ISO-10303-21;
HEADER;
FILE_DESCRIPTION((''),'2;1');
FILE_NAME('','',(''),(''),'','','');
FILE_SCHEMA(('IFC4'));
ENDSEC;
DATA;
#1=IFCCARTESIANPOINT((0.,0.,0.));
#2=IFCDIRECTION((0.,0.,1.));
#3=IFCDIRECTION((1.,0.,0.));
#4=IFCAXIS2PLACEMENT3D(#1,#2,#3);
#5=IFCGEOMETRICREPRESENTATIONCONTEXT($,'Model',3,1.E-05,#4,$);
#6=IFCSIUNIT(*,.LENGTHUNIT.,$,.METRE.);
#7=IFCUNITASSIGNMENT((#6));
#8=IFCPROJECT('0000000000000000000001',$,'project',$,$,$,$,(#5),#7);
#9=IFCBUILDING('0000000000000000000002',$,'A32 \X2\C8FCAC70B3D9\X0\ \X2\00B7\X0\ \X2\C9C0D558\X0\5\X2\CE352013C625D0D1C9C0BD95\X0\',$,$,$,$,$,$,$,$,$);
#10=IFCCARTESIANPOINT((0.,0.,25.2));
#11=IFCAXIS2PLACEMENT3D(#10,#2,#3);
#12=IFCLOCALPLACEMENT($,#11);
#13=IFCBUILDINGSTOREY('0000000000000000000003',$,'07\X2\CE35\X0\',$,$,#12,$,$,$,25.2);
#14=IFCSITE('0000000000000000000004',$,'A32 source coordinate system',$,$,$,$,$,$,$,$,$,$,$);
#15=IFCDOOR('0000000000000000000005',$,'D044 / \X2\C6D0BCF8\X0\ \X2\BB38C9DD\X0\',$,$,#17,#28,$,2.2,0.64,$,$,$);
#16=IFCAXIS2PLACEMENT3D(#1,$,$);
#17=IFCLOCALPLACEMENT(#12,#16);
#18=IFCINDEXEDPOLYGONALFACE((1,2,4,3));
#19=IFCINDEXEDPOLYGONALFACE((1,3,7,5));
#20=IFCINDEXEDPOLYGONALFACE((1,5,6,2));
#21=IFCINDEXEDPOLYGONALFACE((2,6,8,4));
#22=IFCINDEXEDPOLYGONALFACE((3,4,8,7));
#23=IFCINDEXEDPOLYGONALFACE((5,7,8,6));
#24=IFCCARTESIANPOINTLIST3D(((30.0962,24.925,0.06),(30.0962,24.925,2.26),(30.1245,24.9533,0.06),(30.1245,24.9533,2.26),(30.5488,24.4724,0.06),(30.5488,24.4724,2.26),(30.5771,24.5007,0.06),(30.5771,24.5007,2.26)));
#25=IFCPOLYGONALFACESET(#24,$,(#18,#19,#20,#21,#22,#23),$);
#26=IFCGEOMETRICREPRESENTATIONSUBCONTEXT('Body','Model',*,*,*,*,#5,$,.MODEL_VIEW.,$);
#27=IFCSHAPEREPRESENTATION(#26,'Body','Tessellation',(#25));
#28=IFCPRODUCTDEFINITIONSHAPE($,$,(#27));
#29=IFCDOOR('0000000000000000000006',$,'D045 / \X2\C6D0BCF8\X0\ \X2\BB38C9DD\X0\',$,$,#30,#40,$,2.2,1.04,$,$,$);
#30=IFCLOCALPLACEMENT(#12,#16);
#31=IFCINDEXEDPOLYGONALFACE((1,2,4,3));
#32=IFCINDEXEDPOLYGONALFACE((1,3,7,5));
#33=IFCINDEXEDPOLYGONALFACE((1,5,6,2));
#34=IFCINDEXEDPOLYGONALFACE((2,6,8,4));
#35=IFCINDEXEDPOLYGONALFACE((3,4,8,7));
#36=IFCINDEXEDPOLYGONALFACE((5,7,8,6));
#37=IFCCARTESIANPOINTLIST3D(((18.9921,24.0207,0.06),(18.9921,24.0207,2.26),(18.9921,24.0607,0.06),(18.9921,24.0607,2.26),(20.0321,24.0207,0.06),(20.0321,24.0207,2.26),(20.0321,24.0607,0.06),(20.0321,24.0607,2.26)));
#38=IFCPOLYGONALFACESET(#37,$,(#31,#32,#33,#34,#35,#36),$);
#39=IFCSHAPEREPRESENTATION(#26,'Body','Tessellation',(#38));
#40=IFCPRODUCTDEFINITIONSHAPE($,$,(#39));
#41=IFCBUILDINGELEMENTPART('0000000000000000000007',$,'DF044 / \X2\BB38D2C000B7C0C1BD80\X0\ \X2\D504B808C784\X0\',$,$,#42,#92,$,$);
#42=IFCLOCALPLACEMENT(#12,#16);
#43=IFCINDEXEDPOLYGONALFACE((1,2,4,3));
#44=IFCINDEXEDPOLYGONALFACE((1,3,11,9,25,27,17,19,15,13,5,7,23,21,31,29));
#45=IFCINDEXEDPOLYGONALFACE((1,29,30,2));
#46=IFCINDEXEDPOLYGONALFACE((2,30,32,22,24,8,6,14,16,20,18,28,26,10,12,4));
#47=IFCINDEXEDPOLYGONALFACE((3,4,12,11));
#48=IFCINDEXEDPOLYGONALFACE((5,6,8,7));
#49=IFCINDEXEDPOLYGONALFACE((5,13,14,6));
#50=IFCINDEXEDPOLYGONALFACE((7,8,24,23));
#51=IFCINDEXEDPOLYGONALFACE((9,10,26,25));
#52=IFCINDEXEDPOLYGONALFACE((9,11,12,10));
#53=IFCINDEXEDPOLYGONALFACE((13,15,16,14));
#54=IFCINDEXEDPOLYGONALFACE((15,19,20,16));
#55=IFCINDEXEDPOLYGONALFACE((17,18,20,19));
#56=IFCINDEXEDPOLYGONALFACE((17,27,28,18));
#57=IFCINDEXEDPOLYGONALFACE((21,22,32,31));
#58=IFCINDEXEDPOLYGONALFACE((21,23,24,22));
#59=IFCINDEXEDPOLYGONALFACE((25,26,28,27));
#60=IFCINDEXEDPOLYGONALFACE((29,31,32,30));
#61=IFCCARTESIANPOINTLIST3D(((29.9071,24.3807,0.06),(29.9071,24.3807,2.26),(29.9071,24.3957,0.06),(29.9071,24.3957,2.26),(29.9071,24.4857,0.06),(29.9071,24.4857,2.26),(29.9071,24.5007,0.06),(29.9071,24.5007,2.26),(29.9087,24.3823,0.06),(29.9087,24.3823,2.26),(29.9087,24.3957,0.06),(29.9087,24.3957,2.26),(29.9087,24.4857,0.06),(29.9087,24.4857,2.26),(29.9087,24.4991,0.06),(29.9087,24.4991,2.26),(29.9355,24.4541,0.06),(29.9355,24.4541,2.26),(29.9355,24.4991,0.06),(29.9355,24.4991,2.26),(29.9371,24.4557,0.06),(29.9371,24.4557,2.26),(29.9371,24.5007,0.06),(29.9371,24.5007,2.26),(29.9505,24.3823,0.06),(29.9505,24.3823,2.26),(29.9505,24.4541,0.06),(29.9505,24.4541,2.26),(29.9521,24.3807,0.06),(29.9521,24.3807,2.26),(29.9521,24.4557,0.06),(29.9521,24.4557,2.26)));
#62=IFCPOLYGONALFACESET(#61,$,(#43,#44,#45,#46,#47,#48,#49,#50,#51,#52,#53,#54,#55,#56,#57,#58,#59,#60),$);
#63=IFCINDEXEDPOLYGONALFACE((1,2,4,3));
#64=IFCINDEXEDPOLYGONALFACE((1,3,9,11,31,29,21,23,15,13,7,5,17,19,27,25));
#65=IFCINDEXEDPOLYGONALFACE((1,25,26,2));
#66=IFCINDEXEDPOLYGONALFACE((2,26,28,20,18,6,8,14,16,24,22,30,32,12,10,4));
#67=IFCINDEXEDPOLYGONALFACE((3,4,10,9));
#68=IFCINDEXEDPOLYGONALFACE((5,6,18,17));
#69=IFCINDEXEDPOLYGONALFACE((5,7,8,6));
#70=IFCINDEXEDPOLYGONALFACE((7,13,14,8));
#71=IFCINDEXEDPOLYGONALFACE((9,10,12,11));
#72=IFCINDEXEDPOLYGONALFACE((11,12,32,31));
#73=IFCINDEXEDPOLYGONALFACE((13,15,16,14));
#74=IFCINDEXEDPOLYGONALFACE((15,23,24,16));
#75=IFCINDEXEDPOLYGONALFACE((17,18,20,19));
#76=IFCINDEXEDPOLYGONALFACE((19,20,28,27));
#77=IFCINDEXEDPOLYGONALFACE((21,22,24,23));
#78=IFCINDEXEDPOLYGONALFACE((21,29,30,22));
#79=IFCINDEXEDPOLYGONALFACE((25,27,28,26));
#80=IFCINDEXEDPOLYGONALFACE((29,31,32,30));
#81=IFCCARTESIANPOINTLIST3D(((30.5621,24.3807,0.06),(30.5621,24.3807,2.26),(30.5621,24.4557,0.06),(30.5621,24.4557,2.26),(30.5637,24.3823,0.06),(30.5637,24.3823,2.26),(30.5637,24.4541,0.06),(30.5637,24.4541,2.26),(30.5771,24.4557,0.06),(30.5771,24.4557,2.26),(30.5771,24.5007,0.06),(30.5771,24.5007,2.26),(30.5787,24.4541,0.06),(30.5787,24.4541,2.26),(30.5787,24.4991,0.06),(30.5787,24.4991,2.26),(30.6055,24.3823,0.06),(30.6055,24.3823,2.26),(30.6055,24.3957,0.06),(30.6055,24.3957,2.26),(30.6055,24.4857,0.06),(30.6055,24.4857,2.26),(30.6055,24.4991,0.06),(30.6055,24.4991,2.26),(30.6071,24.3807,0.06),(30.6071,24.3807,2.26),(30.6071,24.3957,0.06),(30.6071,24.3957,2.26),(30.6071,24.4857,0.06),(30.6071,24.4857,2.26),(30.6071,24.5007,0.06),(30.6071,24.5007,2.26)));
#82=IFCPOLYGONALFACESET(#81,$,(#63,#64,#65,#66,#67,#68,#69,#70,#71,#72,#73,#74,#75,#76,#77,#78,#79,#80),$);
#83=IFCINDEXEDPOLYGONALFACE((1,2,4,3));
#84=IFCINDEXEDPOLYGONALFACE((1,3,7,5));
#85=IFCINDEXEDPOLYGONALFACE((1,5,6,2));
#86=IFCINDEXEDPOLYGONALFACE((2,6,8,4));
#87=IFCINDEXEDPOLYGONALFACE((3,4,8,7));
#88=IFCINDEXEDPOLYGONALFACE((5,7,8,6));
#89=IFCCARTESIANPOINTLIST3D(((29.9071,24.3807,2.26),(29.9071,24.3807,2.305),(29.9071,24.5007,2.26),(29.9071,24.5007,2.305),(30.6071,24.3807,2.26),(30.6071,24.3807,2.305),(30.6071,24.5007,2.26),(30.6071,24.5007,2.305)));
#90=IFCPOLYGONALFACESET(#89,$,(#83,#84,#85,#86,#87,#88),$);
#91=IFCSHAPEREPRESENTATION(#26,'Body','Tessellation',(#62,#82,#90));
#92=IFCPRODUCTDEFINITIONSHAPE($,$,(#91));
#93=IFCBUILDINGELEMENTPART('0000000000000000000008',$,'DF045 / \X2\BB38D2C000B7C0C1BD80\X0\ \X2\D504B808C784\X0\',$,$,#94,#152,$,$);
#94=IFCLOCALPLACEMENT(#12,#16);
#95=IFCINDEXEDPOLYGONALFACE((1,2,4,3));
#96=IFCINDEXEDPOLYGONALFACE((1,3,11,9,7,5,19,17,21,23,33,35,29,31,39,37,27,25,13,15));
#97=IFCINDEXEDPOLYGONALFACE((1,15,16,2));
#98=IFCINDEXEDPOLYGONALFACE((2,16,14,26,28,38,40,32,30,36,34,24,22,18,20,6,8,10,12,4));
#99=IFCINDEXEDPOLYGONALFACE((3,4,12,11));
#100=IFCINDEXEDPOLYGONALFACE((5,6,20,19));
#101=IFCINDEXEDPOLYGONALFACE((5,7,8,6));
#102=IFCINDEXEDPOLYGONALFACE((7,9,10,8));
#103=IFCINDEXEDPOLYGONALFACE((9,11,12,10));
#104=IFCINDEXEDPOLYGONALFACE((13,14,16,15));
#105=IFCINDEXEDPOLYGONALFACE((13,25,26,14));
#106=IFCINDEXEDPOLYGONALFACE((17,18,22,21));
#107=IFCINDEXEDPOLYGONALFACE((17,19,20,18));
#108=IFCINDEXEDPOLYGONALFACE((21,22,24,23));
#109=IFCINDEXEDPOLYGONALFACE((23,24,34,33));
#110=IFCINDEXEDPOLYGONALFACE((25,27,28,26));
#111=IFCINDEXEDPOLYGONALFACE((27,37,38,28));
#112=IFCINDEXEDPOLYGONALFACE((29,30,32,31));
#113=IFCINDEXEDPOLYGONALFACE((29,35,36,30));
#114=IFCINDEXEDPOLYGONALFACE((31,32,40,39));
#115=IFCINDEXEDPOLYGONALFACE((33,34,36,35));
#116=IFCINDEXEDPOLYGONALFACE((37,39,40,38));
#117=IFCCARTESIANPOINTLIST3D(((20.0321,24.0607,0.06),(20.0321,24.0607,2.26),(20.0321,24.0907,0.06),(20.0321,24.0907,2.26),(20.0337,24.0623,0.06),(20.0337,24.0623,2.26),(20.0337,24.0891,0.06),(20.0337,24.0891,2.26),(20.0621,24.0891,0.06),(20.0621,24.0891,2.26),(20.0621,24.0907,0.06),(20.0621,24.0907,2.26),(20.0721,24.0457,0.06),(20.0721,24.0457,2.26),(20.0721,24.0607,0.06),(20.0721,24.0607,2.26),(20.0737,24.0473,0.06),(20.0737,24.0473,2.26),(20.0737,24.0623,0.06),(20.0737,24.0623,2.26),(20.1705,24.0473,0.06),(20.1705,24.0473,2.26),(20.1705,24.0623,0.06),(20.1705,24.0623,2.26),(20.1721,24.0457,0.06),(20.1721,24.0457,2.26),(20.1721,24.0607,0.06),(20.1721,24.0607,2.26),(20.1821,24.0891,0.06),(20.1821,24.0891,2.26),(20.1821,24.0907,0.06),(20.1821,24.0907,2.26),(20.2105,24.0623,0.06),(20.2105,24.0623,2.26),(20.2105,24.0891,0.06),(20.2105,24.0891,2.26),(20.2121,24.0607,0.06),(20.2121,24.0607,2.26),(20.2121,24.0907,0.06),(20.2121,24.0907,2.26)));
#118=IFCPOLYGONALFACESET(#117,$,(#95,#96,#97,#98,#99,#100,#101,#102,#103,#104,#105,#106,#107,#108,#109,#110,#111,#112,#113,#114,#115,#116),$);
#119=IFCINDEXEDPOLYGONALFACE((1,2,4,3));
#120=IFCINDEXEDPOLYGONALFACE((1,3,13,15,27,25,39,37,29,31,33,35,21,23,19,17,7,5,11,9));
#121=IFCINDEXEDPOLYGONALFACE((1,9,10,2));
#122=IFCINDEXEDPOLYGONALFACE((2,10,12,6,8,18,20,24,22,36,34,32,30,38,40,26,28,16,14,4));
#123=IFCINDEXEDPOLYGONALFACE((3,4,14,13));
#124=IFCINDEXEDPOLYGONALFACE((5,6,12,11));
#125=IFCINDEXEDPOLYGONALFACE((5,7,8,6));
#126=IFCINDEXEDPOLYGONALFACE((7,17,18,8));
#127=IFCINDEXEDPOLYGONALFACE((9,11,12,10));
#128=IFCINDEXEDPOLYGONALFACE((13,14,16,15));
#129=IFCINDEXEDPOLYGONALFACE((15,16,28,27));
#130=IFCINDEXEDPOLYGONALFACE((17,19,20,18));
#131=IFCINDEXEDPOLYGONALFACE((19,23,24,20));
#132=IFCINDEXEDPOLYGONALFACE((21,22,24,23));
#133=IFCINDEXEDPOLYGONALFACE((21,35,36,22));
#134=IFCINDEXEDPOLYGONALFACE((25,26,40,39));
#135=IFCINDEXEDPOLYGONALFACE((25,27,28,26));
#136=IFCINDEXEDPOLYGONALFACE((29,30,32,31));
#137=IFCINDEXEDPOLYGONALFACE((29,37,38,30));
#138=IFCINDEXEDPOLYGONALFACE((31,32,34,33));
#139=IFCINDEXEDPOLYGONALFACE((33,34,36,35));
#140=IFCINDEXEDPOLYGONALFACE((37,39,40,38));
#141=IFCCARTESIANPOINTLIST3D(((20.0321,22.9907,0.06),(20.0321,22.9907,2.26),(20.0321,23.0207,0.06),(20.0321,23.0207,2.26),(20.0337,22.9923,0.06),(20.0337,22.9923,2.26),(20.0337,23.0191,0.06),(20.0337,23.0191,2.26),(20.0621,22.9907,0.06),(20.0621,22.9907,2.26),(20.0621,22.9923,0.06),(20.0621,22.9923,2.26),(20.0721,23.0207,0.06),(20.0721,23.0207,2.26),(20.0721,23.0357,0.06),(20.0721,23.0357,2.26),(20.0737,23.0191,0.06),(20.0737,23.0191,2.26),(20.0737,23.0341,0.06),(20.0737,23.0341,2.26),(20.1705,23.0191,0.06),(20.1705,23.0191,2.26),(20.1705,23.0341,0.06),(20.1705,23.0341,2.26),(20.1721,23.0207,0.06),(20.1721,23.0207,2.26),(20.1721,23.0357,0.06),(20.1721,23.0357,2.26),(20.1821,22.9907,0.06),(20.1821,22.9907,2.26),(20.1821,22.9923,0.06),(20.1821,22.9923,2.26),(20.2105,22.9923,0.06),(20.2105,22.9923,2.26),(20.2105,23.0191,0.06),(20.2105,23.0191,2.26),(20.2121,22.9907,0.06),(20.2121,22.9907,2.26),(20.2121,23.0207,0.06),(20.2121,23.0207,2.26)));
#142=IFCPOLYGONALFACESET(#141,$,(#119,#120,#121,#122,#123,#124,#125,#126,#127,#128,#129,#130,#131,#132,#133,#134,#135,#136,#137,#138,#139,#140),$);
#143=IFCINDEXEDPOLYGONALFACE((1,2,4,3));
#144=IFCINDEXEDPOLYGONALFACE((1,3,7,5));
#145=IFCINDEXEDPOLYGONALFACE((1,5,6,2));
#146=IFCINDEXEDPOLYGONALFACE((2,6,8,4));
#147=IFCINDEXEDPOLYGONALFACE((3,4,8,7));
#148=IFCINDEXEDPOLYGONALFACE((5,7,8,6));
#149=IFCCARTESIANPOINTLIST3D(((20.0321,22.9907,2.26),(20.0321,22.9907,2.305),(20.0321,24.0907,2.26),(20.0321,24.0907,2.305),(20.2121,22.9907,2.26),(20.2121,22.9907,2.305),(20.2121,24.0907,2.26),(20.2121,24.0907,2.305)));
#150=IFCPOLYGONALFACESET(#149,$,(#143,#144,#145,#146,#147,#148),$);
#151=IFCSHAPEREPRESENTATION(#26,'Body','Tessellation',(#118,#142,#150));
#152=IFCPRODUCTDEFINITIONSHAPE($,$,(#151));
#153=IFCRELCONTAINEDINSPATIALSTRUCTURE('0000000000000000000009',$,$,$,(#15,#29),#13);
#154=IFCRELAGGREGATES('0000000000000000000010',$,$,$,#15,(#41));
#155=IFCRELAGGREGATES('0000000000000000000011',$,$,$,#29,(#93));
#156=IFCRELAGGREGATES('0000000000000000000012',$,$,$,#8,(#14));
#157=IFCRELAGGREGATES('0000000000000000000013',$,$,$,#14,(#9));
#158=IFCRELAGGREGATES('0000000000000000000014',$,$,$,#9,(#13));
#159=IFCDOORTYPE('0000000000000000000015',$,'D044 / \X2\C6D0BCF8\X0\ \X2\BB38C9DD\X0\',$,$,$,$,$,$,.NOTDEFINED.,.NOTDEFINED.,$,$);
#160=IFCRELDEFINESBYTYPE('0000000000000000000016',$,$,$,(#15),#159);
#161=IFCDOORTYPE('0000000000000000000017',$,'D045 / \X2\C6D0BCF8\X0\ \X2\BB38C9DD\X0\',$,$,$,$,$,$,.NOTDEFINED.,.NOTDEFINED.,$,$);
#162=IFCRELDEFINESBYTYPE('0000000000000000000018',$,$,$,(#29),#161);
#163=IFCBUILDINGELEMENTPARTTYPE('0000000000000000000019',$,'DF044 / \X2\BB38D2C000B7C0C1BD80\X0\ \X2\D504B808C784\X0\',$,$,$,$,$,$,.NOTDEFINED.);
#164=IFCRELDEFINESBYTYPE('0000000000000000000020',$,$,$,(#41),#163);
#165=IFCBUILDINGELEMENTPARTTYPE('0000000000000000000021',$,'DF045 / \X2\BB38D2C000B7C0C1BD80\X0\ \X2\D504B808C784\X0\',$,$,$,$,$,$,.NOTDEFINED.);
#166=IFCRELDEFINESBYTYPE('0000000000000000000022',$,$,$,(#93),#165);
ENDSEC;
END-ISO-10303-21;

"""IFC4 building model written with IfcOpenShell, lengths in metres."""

from ifc_helpers import new_model, si_unit, frame, origin, origin_with_axes, place, context, subcontext, project, spatial, polyline, outline, extrude, source, transform, mapped, type_object, type_shapes, element, aggregate, save


model = new_model("IFC4")

# Units and contexts
model_context = context("Model", 3, precision=1e-05, world=origin_with_axes())
body_context = subcontext(model_context, "Body", "Model", "MODEL_VIEW")
ifc_project = project(units=[si_unit("LENGTHUNIT", "METRE")], contexts=[model_context])

# Site, building, storey
storey_placement = place(None, frame((0.0, 0.0, 25.2), z_axis=(0.0, 0.0, 1.0), x_axis=(1.0, 0.0, 0.0)))
site = spatial("IfcSite", under=ifc_project, Name="A32 source coordinate system")
building = spatial("IfcBuilding", under=site, Name="A32 주거동 · 지하5층–옥탑지붕")
storey = spatial("IfcBuildingStorey", under=building, at=storey_placement, Name="07층", Elevation=25.2)

# Doors
door_type_1 = type_object("IfcDoorType", Name="D044 / 원본 문짝", OperationType="NOTDEFINED", PredefinedType="NOTDEFINED")
shared_shape_1 = source(origin(), body_context, "Body", "SweptSolid", [
    extrude(outline(polyline([(30.5771, 24.5007), (30.5488, 24.4724), (30.0962, 24.925), (30.1245, 24.9533), (30.5771, 24.5007)])), frame((0.0, 0.0, 0.06)), (0.0, 0.0, 1.0), 2.2),
])
type_shapes(door_type_1, [shared_shape_1])
door_1_placement = place(storey_placement, origin_with_axes())
door_1 = element("IfcDoor", 1, at=door_1_placement, inside=storey, type_object=door_type_1, Name="D044 / 원본 문짝", OverallHeight=2.2, OverallWidth=0.64, context=body_context, shape_type="MappedRepresentation", body=[
    mapped(shared_shape_1, transform((0.0, 0.0, 0.0), scale=1.0)),
])
door_type_2 = type_object("IfcDoorType", Name="D045 / 원본 문짝", OperationType="NOTDEFINED", PredefinedType="NOTDEFINED")
shared_shape_2 = source(origin(), body_context, "Body", "SweptSolid", [
    extrude(outline(polyline([(20.0321, 24.0607), (20.0321, 24.0207), (18.9921, 24.0207), (18.9921, 24.0607), (20.0321, 24.0607)])), frame((0.0, 0.0, 0.06)), (0.0, 0.0, 1.0), 2.2),
])
type_shapes(door_type_2, [shared_shape_2])
door_2_placement = place(storey_placement, origin_with_axes())
door_2 = element("IfcDoor", 2, at=door_2_placement, inside=storey, type_object=door_type_2, Name="D045 / 원본 문짝", OverallHeight=2.2, OverallWidth=1.04, context=body_context, shape_type="MappedRepresentation", body=[
    mapped(shared_shape_2, transform((0.0, 0.0, 0.0), scale=1.0)),
])

# Building element parts
building_element_part_type_1 = type_object("IfcBuildingElementPartType", Name="DF044 / 문틀·상부 프레임", PredefinedType="NOTDEFINED")
shared_shape_3 = source(origin(), body_context, "Body", "SweptSolid", [
    extrude(outline(polyline([(29.9071, 24.4857), (29.9071, 24.5007), (29.9371, 24.5007), (29.9371, 24.4557), (29.9521, 24.4557), (29.9521, 24.3807), (29.9071, 24.3807), (29.9071, 24.3957), (29.9087, 24.3957), (29.9087, 24.3823), (29.9505, 24.3823), (29.9505, 24.4541), (29.9355, 24.4541), (29.9355, 24.4991), (29.9087, 24.4991), (29.9087, 24.4857), (29.9071, 24.4857)])), frame((0.0, 0.0, 0.06)), (0.0, 0.0, 1.0), 2.2),
    extrude(outline(polyline([(30.6055, 24.4991), (30.5787, 24.4991), (30.5787, 24.4541), (30.5637, 24.4541), (30.5637, 24.3823), (30.6055, 24.3823), (30.6055, 24.3957), (30.6071, 24.3957), (30.6071, 24.3807), (30.5621, 24.3807), (30.5621, 24.4557), (30.5771, 24.4557), (30.5771, 24.5007), (30.6071, 24.5007), (30.6071, 24.4857), (30.6055, 24.4857), (30.6055, 24.4991)])), frame((0.0, 0.0, 0.06)), (0.0, 0.0, 1.0), 2.2),
    extrude(outline(polyline([(29.9071, 24.3807), (29.9071, 24.5007), (30.6071, 24.5007), (30.6071, 24.3807), (29.9071, 24.3807)])), frame((0.0, 0.0, 2.26)), (0.0, 0.0, 1.0), 0.045),
])
type_shapes(building_element_part_type_1, [shared_shape_3])
building_element_part_1_placement = place(door_1_placement, origin_with_axes())
building_element_part_1 = element("IfcBuildingElementPart", 3, at=building_element_part_1_placement, type_object=building_element_part_type_1, Name="DF044 / 문틀·상부 프레임", context=body_context, shape_type="MappedRepresentation", body=[
    mapped(shared_shape_3, transform((0.0, 0.0, 0.0), scale=1.0)),
])
aggregate(door_1, [building_element_part_1])
building_element_part_type_2 = type_object("IfcBuildingElementPartType", Name="DF045 / 문틀·상부 프레임", PredefinedType="NOTDEFINED")
shared_shape_4 = source(origin(), body_context, "Body", "SweptSolid", [
    extrude(outline(polyline([(20.0337, 24.0891), (20.0337, 24.0623), (20.0737, 24.0623), (20.0737, 24.0473), (20.1705, 24.0473), (20.1705, 24.0623), (20.2105, 24.0623), (20.2105, 24.0891), (20.1821, 24.0891), (20.1821, 24.0907), (20.2121, 24.0907), (20.2121, 24.0607), (20.1721, 24.0607), (20.1721, 24.0457), (20.0721, 24.0457), (20.0721, 24.0607), (20.0321, 24.0607), (20.0321, 24.0907), (20.0621, 24.0907), (20.0621, 24.0891), (20.0337, 24.0891)])), frame((0.0, 0.0, 0.06)), (0.0, 0.0, 1.0), 2.2),
    extrude(outline(polyline([(20.0621, 22.9907), (20.0321, 22.9907), (20.0321, 23.0207), (20.0721, 23.0207), (20.0721, 23.0357), (20.1721, 23.0357), (20.1721, 23.0207), (20.2121, 23.0207), (20.2121, 22.9907), (20.1821, 22.9907), (20.1821, 22.9923), (20.2105, 22.9923), (20.2105, 23.0191), (20.1705, 23.0191), (20.1705, 23.0341), (20.0737, 23.0341), (20.0737, 23.0191), (20.0337, 23.0191), (20.0337, 22.9923), (20.0621, 22.9923), (20.0621, 22.9907)])), frame((0.0, 0.0, 0.06)), (0.0, 0.0, 1.0), 2.2),
    extrude(outline(polyline([(20.0321, 22.9907), (20.0321, 24.0907), (20.2121, 24.0907), (20.2121, 22.9907), (20.0321, 22.9907)])), frame((0.0, 0.0, 2.26)), (0.0, 0.0, 1.0), 0.045),
])
type_shapes(building_element_part_type_2, [shared_shape_4])
building_element_part_2_placement = place(door_2_placement, origin_with_axes())
building_element_part_2 = element("IfcBuildingElementPart", 4, at=building_element_part_2_placement, type_object=building_element_part_type_2, Name="DF045 / 문틀·상부 프레임", context=body_context, shape_type="MappedRepresentation", body=[
    mapped(shared_shape_4, transform((0.0, 0.0, 0.0), scale=1.0)),
])
aggregate(door_2, [building_element_part_2])

save(model, "model.ifc")
